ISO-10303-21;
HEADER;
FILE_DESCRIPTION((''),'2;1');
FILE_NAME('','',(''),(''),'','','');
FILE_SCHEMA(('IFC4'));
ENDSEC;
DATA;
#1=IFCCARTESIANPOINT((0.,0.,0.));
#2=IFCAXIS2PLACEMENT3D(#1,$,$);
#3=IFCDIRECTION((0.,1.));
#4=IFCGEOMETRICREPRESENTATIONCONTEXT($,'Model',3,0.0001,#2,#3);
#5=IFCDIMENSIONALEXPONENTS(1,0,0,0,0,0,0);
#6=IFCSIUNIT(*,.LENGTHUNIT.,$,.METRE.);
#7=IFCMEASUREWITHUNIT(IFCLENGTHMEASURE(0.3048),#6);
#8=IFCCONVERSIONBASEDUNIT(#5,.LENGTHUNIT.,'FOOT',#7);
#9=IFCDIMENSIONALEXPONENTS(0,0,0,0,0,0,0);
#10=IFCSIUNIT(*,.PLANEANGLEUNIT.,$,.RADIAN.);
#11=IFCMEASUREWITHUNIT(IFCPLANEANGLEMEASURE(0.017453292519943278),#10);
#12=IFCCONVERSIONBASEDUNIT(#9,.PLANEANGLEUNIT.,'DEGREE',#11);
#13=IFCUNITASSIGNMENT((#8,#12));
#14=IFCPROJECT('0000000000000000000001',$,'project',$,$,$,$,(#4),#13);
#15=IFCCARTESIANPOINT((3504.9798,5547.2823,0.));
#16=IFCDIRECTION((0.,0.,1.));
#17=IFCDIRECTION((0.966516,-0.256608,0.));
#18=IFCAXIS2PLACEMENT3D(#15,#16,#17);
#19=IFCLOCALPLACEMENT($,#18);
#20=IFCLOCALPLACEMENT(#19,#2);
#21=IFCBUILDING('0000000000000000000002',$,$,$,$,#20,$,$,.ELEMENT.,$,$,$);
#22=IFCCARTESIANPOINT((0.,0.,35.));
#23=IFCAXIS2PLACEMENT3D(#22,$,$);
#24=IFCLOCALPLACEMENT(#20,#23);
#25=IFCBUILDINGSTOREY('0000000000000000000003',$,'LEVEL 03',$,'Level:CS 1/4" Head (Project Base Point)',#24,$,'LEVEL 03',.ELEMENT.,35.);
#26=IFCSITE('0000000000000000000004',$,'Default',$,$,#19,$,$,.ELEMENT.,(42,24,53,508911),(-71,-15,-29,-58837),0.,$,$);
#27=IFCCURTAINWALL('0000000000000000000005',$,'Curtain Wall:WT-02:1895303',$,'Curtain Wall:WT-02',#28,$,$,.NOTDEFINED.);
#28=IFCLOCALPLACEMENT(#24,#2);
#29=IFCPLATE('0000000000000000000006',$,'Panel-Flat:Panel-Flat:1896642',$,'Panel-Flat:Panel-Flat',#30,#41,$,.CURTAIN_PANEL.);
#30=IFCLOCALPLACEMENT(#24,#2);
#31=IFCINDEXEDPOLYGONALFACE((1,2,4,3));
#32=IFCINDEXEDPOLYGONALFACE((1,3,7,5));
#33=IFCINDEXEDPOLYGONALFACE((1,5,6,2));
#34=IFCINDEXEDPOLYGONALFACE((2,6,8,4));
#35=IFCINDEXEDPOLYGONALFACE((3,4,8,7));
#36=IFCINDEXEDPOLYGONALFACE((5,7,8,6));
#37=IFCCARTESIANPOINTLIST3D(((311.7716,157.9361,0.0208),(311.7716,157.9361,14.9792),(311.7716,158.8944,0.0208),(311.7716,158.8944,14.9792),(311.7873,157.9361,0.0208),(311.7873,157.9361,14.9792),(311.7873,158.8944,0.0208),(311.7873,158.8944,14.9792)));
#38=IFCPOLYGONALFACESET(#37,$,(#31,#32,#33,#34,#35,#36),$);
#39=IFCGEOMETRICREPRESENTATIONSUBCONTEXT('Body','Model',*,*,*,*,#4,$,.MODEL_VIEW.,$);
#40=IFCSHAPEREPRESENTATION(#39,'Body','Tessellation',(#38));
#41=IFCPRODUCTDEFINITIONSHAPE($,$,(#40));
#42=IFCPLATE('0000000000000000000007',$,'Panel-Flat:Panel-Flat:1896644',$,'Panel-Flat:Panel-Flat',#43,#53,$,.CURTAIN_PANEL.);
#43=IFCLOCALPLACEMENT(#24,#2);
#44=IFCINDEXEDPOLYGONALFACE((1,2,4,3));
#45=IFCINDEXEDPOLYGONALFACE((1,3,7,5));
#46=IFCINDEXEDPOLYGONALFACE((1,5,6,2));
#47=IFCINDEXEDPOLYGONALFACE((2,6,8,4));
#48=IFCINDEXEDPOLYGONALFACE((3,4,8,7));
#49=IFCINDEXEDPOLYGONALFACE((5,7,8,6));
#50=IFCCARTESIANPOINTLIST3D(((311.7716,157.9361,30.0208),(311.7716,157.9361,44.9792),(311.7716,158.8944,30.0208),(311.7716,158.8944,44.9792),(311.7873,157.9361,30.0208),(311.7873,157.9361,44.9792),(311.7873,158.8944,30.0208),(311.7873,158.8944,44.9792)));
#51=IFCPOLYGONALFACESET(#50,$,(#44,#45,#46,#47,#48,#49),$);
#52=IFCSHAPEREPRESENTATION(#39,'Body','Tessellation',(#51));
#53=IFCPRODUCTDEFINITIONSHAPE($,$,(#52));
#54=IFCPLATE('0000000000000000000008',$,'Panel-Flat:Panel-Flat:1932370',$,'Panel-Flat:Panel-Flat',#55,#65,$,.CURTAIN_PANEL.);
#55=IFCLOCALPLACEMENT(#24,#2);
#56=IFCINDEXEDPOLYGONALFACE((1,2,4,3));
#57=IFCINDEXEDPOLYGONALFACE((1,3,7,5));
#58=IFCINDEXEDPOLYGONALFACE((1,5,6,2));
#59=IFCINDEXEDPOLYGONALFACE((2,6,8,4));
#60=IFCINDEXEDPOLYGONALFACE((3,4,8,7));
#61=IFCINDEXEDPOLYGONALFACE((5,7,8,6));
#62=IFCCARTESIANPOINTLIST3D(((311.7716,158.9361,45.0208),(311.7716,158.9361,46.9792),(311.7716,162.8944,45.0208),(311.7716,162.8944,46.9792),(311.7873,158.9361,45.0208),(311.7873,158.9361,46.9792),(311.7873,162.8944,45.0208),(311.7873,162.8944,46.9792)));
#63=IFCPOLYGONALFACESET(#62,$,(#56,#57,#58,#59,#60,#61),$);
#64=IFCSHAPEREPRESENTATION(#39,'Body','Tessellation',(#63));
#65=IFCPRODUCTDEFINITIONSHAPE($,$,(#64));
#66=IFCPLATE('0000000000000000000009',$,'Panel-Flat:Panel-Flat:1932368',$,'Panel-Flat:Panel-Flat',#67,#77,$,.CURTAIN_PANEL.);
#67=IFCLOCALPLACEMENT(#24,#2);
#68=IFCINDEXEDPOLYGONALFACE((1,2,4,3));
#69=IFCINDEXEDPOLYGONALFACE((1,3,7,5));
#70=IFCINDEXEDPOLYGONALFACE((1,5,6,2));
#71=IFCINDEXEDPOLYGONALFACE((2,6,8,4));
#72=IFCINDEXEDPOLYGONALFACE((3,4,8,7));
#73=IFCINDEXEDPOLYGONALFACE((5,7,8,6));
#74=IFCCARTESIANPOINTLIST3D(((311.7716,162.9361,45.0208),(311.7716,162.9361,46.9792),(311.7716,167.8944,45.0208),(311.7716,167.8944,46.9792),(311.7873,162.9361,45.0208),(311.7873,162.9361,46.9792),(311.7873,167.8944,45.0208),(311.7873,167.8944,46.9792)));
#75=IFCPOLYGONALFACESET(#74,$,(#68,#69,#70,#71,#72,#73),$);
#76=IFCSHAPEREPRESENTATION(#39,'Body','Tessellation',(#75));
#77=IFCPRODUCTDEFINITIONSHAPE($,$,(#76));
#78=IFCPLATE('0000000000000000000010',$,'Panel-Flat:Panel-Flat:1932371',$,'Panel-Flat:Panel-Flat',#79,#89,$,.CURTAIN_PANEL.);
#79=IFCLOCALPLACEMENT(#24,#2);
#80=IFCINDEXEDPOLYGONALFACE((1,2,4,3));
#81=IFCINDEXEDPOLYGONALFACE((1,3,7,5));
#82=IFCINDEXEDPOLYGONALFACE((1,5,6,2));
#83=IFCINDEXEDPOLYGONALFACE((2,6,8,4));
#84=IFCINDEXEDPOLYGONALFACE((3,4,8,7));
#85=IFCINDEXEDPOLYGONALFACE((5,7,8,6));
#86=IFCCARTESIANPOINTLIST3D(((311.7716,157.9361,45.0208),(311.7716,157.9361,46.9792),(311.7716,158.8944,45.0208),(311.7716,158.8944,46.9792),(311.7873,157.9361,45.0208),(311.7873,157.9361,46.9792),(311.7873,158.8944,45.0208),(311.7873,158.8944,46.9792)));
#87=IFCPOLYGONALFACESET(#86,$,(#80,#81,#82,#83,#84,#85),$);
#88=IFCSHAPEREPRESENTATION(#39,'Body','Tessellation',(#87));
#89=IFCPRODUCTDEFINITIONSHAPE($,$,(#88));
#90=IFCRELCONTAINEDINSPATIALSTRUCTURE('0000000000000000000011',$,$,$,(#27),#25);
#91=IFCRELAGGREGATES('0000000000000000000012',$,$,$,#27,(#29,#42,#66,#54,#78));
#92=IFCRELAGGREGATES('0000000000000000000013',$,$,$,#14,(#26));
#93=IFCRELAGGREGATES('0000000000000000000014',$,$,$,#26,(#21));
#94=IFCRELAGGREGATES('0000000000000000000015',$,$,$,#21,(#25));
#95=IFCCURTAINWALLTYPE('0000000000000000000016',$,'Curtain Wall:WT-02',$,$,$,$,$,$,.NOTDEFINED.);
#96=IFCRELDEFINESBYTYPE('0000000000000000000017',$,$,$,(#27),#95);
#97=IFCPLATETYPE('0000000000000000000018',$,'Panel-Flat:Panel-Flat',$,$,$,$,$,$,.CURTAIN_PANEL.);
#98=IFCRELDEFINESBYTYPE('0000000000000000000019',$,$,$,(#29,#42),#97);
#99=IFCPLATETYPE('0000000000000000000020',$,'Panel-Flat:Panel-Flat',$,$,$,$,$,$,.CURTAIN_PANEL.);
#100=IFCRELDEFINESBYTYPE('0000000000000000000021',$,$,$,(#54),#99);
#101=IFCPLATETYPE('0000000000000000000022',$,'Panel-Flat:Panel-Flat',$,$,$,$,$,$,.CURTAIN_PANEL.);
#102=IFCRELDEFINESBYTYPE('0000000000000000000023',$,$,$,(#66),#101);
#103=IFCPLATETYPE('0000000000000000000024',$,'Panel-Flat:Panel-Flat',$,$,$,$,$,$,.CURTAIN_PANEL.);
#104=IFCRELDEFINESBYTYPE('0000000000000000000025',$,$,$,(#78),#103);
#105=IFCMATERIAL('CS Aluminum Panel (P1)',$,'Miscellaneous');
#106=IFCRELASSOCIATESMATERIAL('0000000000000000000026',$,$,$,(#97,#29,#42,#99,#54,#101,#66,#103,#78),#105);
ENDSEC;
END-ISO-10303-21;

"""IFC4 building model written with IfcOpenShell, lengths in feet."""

from ifc_helpers import new_model, entity, si_unit, converted_unit, direction, frame, origin, place, context, subcontext, project, spatial, indexed_curve, outline, extrude, source, transform, mapped, material, type_object, type_shapes, element, aggregate, save


model = new_model("IFC4")

# Units and contexts
model_context = context("Model", 3, precision=0.0001, world=origin(), true_north=direction((0.0, 1.0)))
body_context = subcontext(model_context, "Body", "Model", "MODEL_VIEW")
ifc_project = project(units=[converted_unit("LENGTHUNIT", "FOOT", entity("IfcLengthMeasure", 0.3048), si_unit("LENGTHUNIT", "METRE"), dimensions=[1, 0, 0, 0, 0, 0, 0]), converted_unit("PLANEANGLEUNIT", "DEGREE", entity("IfcPlaneAngleMeasure", 0.017453292519943278), si_unit("PLANEANGLEUNIT", "RADIAN"), dimensions=[0, 0, 0, 0, 0, 0, 0])], contexts=[model_context])

# Site, building, storey
site_placement = place(None, frame((3504.9798, 5547.2823, 0.0), z_axis=(0.0, 0.0, 1.0), x_axis=(0.966516, -0.256608, 0.0)))
site = spatial("IfcSite", under=ifc_project, at=site_placement, Name="Default", CompositionType="ELEMENT", RefLatitude=(42, 24, 53, 508911), RefLongitude=(-71, -15, -29, -58837), RefElevation=0.0)
building_placement = place(site_placement, origin())
building = spatial("IfcBuilding", under=site, at=building_placement, CompositionType="ELEMENT")
storey_placement = place(building_placement, frame((0.0, 0.0, 35.0)))
storey = spatial("IfcBuildingStorey", under=building, at=storey_placement, Name="LEVEL 03", ObjectType="Level:CS 1/4\" Head (Project Base Point)", LongName="LEVEL 03", CompositionType="ELEMENT", Elevation=35.0)

# Curtain wall, plates
curtain_wall_type = type_object("IfcCurtainWallType", Name="Curtain Wall:WT-02", PredefinedType="NOTDEFINED")
curtain_wall_placement = place(storey_placement, frame((0.0, 0.0, -35.0)))
curtain_wall = element("IfcCurtainWall", 1, at=curtain_wall_placement, inside=storey, type_object=curtain_wall_type, Name="Curtain Wall:WT-02:1895303", ObjectType="Curtain Wall:WT-02", PredefinedType="NOTDEFINED")
ifc_material_1 = material(Name="CS Aluminum Panel (P1)", Category="Miscellaneous")
plate_type_1 = type_object("IfcPlateType", Name="Panel-Flat:Panel-Flat", PredefinedType="CURTAIN_PANEL", material=ifc_material_1)
shared_shape_1 = source(origin(), body_context, "Body", "SweptSolid", [
    extrude(outline(indexed_curve([(-0.0078, -0.4792), (0.0078, -0.4792), (0.0078, 0.4792), (-0.0078, 0.4792), (-0.0078, -0.4792)], self_intersect=False)), frame((0.0, -0.0078, 0.0208), z_axis=(0.0, 0.0, 1.0), x_axis=(0.0, -1.0, 0.0)), (0.0, 0.0, 1.0), 14.9583),
])
type_shapes(plate_type_1, [shared_shape_1])
plate_1_placement = place(curtain_wall_placement, frame((311.7873, 158.4153, 35.0), z_axis=(0.0, 0.0, 1.0), x_axis=(0.0, -1.0, 0.0)))
plate_1 = element("IfcPlate", 2, at=plate_1_placement, type_object=plate_type_1, material=ifc_material_1, Name="Panel-Flat:Panel-Flat:1896642", ObjectType="Panel-Flat:Panel-Flat", PredefinedType="CURTAIN_PANEL", context=body_context, shape_type="MappedRepresentation", body=[
    mapped(shared_shape_1, transform((0.0, 0.0, 0.0), scale=1.0)),
])
plate_2_placement = place(curtain_wall_placement, frame((311.7873, 158.4153, 65.0), z_axis=(0.0, 0.0, 1.0), x_axis=(0.0, -1.0, 0.0)))
plate_2 = element("IfcPlate", 3, at=plate_2_placement, type_object=plate_type_1, material=ifc_material_1, Name="Panel-Flat:Panel-Flat:1896644", ObjectType="Panel-Flat:Panel-Flat", PredefinedType="CURTAIN_PANEL", context=body_context, shape_type="MappedRepresentation", body=[
    mapped(shared_shape_1, transform((0.0, 0.0, 0.0), scale=1.0)),
])
plate_type_2 = type_object("IfcPlateType", Name="Panel-Flat:Panel-Flat", PredefinedType="CURTAIN_PANEL", material=ifc_material_1)
shared_shape_2 = source(origin(), body_context, "Body", "SweptSolid", [
    extrude(outline(indexed_curve([(-0.0078, -1.9792), (0.0078, -1.9792), (0.0078, 1.9792), (-0.0078, 1.9792), (-0.0078, -1.9792)], self_intersect=False)), frame((0.0, -0.0078, 0.0208), z_axis=(0.0, 0.0, 1.0), x_axis=(0.0, -1.0, 0.0)), (0.0, 0.0, 1.0), 1.9583),
])
type_shapes(plate_type_2, [shared_shape_2])
plate_3_placement = place(curtain_wall_placement, frame((311.7873, 160.9153, 80.0), z_axis=(0.0, 0.0, 1.0), x_axis=(0.0, -1.0, 0.0)))
plate_3 = element("IfcPlate", 4, at=plate_3_placement, type_object=plate_type_2, material=ifc_material_1, Name="Panel-Flat:Panel-Flat:1932370", ObjectType="Panel-Flat:Panel-Flat", PredefinedType="CURTAIN_PANEL", context=body_context, shape_type="MappedRepresentation", body=[
    mapped(shared_shape_2, transform((0.0, 0.0, 0.0), scale=1.0)),
])
plate_type_3 = type_object("IfcPlateType", Name="Panel-Flat:Panel-Flat", PredefinedType="CURTAIN_PANEL", material=ifc_material_1)
shared_shape_3 = source(origin(), body_context, "Body", "SweptSolid", [
    extrude(outline(indexed_curve([(-0.0078, -2.4792), (0.0078, -2.4792), (0.0078, 2.4792), (-0.0078, 2.4792), (-0.0078, -2.4792)], self_intersect=False)), frame((0.0, -0.0078, 0.0208), z_axis=(0.0, 0.0, 1.0), x_axis=(0.0, -1.0, 0.0)), (0.0, 0.0, 1.0), 1.9583),
])
type_shapes(plate_type_3, [shared_shape_3])
plate_4_placement = place(curtain_wall_placement, frame((311.7873, 165.4153, 80.0), z_axis=(0.0, 0.0, 1.0), x_axis=(0.0, -1.0, 0.0)))
plate_4 = element("IfcPlate", 5, at=plate_4_placement, type_object=plate_type_3, material=ifc_material_1, Name="Panel-Flat:Panel-Flat:1932368", ObjectType="Panel-Flat:Panel-Flat", PredefinedType="CURTAIN_PANEL", context=body_context, shape_type="MappedRepresentation", body=[
    mapped(shared_shape_3, transform((0.0, 0.0, 0.0), scale=1.0)),
])
plate_type_4 = type_object("IfcPlateType", Name="Panel-Flat:Panel-Flat", PredefinedType="CURTAIN_PANEL", material=ifc_material_1)
shared_shape_4 = source(origin(), body_context, "Body", "SweptSolid", [
    extrude(outline(indexed_curve([(-0.0078, -0.4792), (0.0078, -0.4792), (0.0078, 0.4792), (-0.0078, 0.4792), (-0.0078, -0.4792)], self_intersect=False)), frame((0.0, -0.0078, 0.0208), z_axis=(0.0, 0.0, 1.0), x_axis=(0.0, -1.0, 0.0)), (0.0, 0.0, 1.0), 1.9583),
])
type_shapes(plate_type_4, [shared_shape_4])
plate_5_placement = place(curtain_wall_placement, frame((311.7873, 158.4153, 80.0), z_axis=(0.0, 0.0, 1.0), x_axis=(0.0, -1.0, 0.0)))
plate_5 = element("IfcPlate", 6, at=plate_5_placement, type_object=plate_type_4, material=ifc_material_1, Name="Panel-Flat:Panel-Flat:1932371", ObjectType="Panel-Flat:Panel-Flat", PredefinedType="CURTAIN_PANEL", context=body_context, shape_type="MappedRepresentation", body=[
    mapped(shared_shape_4, transform((0.0, 0.0, 0.0), scale=1.0)),
])
aggregate(curtain_wall, [plate_1, plate_2, plate_4, plate_3, plate_5])

save(model, "model.ifc")
